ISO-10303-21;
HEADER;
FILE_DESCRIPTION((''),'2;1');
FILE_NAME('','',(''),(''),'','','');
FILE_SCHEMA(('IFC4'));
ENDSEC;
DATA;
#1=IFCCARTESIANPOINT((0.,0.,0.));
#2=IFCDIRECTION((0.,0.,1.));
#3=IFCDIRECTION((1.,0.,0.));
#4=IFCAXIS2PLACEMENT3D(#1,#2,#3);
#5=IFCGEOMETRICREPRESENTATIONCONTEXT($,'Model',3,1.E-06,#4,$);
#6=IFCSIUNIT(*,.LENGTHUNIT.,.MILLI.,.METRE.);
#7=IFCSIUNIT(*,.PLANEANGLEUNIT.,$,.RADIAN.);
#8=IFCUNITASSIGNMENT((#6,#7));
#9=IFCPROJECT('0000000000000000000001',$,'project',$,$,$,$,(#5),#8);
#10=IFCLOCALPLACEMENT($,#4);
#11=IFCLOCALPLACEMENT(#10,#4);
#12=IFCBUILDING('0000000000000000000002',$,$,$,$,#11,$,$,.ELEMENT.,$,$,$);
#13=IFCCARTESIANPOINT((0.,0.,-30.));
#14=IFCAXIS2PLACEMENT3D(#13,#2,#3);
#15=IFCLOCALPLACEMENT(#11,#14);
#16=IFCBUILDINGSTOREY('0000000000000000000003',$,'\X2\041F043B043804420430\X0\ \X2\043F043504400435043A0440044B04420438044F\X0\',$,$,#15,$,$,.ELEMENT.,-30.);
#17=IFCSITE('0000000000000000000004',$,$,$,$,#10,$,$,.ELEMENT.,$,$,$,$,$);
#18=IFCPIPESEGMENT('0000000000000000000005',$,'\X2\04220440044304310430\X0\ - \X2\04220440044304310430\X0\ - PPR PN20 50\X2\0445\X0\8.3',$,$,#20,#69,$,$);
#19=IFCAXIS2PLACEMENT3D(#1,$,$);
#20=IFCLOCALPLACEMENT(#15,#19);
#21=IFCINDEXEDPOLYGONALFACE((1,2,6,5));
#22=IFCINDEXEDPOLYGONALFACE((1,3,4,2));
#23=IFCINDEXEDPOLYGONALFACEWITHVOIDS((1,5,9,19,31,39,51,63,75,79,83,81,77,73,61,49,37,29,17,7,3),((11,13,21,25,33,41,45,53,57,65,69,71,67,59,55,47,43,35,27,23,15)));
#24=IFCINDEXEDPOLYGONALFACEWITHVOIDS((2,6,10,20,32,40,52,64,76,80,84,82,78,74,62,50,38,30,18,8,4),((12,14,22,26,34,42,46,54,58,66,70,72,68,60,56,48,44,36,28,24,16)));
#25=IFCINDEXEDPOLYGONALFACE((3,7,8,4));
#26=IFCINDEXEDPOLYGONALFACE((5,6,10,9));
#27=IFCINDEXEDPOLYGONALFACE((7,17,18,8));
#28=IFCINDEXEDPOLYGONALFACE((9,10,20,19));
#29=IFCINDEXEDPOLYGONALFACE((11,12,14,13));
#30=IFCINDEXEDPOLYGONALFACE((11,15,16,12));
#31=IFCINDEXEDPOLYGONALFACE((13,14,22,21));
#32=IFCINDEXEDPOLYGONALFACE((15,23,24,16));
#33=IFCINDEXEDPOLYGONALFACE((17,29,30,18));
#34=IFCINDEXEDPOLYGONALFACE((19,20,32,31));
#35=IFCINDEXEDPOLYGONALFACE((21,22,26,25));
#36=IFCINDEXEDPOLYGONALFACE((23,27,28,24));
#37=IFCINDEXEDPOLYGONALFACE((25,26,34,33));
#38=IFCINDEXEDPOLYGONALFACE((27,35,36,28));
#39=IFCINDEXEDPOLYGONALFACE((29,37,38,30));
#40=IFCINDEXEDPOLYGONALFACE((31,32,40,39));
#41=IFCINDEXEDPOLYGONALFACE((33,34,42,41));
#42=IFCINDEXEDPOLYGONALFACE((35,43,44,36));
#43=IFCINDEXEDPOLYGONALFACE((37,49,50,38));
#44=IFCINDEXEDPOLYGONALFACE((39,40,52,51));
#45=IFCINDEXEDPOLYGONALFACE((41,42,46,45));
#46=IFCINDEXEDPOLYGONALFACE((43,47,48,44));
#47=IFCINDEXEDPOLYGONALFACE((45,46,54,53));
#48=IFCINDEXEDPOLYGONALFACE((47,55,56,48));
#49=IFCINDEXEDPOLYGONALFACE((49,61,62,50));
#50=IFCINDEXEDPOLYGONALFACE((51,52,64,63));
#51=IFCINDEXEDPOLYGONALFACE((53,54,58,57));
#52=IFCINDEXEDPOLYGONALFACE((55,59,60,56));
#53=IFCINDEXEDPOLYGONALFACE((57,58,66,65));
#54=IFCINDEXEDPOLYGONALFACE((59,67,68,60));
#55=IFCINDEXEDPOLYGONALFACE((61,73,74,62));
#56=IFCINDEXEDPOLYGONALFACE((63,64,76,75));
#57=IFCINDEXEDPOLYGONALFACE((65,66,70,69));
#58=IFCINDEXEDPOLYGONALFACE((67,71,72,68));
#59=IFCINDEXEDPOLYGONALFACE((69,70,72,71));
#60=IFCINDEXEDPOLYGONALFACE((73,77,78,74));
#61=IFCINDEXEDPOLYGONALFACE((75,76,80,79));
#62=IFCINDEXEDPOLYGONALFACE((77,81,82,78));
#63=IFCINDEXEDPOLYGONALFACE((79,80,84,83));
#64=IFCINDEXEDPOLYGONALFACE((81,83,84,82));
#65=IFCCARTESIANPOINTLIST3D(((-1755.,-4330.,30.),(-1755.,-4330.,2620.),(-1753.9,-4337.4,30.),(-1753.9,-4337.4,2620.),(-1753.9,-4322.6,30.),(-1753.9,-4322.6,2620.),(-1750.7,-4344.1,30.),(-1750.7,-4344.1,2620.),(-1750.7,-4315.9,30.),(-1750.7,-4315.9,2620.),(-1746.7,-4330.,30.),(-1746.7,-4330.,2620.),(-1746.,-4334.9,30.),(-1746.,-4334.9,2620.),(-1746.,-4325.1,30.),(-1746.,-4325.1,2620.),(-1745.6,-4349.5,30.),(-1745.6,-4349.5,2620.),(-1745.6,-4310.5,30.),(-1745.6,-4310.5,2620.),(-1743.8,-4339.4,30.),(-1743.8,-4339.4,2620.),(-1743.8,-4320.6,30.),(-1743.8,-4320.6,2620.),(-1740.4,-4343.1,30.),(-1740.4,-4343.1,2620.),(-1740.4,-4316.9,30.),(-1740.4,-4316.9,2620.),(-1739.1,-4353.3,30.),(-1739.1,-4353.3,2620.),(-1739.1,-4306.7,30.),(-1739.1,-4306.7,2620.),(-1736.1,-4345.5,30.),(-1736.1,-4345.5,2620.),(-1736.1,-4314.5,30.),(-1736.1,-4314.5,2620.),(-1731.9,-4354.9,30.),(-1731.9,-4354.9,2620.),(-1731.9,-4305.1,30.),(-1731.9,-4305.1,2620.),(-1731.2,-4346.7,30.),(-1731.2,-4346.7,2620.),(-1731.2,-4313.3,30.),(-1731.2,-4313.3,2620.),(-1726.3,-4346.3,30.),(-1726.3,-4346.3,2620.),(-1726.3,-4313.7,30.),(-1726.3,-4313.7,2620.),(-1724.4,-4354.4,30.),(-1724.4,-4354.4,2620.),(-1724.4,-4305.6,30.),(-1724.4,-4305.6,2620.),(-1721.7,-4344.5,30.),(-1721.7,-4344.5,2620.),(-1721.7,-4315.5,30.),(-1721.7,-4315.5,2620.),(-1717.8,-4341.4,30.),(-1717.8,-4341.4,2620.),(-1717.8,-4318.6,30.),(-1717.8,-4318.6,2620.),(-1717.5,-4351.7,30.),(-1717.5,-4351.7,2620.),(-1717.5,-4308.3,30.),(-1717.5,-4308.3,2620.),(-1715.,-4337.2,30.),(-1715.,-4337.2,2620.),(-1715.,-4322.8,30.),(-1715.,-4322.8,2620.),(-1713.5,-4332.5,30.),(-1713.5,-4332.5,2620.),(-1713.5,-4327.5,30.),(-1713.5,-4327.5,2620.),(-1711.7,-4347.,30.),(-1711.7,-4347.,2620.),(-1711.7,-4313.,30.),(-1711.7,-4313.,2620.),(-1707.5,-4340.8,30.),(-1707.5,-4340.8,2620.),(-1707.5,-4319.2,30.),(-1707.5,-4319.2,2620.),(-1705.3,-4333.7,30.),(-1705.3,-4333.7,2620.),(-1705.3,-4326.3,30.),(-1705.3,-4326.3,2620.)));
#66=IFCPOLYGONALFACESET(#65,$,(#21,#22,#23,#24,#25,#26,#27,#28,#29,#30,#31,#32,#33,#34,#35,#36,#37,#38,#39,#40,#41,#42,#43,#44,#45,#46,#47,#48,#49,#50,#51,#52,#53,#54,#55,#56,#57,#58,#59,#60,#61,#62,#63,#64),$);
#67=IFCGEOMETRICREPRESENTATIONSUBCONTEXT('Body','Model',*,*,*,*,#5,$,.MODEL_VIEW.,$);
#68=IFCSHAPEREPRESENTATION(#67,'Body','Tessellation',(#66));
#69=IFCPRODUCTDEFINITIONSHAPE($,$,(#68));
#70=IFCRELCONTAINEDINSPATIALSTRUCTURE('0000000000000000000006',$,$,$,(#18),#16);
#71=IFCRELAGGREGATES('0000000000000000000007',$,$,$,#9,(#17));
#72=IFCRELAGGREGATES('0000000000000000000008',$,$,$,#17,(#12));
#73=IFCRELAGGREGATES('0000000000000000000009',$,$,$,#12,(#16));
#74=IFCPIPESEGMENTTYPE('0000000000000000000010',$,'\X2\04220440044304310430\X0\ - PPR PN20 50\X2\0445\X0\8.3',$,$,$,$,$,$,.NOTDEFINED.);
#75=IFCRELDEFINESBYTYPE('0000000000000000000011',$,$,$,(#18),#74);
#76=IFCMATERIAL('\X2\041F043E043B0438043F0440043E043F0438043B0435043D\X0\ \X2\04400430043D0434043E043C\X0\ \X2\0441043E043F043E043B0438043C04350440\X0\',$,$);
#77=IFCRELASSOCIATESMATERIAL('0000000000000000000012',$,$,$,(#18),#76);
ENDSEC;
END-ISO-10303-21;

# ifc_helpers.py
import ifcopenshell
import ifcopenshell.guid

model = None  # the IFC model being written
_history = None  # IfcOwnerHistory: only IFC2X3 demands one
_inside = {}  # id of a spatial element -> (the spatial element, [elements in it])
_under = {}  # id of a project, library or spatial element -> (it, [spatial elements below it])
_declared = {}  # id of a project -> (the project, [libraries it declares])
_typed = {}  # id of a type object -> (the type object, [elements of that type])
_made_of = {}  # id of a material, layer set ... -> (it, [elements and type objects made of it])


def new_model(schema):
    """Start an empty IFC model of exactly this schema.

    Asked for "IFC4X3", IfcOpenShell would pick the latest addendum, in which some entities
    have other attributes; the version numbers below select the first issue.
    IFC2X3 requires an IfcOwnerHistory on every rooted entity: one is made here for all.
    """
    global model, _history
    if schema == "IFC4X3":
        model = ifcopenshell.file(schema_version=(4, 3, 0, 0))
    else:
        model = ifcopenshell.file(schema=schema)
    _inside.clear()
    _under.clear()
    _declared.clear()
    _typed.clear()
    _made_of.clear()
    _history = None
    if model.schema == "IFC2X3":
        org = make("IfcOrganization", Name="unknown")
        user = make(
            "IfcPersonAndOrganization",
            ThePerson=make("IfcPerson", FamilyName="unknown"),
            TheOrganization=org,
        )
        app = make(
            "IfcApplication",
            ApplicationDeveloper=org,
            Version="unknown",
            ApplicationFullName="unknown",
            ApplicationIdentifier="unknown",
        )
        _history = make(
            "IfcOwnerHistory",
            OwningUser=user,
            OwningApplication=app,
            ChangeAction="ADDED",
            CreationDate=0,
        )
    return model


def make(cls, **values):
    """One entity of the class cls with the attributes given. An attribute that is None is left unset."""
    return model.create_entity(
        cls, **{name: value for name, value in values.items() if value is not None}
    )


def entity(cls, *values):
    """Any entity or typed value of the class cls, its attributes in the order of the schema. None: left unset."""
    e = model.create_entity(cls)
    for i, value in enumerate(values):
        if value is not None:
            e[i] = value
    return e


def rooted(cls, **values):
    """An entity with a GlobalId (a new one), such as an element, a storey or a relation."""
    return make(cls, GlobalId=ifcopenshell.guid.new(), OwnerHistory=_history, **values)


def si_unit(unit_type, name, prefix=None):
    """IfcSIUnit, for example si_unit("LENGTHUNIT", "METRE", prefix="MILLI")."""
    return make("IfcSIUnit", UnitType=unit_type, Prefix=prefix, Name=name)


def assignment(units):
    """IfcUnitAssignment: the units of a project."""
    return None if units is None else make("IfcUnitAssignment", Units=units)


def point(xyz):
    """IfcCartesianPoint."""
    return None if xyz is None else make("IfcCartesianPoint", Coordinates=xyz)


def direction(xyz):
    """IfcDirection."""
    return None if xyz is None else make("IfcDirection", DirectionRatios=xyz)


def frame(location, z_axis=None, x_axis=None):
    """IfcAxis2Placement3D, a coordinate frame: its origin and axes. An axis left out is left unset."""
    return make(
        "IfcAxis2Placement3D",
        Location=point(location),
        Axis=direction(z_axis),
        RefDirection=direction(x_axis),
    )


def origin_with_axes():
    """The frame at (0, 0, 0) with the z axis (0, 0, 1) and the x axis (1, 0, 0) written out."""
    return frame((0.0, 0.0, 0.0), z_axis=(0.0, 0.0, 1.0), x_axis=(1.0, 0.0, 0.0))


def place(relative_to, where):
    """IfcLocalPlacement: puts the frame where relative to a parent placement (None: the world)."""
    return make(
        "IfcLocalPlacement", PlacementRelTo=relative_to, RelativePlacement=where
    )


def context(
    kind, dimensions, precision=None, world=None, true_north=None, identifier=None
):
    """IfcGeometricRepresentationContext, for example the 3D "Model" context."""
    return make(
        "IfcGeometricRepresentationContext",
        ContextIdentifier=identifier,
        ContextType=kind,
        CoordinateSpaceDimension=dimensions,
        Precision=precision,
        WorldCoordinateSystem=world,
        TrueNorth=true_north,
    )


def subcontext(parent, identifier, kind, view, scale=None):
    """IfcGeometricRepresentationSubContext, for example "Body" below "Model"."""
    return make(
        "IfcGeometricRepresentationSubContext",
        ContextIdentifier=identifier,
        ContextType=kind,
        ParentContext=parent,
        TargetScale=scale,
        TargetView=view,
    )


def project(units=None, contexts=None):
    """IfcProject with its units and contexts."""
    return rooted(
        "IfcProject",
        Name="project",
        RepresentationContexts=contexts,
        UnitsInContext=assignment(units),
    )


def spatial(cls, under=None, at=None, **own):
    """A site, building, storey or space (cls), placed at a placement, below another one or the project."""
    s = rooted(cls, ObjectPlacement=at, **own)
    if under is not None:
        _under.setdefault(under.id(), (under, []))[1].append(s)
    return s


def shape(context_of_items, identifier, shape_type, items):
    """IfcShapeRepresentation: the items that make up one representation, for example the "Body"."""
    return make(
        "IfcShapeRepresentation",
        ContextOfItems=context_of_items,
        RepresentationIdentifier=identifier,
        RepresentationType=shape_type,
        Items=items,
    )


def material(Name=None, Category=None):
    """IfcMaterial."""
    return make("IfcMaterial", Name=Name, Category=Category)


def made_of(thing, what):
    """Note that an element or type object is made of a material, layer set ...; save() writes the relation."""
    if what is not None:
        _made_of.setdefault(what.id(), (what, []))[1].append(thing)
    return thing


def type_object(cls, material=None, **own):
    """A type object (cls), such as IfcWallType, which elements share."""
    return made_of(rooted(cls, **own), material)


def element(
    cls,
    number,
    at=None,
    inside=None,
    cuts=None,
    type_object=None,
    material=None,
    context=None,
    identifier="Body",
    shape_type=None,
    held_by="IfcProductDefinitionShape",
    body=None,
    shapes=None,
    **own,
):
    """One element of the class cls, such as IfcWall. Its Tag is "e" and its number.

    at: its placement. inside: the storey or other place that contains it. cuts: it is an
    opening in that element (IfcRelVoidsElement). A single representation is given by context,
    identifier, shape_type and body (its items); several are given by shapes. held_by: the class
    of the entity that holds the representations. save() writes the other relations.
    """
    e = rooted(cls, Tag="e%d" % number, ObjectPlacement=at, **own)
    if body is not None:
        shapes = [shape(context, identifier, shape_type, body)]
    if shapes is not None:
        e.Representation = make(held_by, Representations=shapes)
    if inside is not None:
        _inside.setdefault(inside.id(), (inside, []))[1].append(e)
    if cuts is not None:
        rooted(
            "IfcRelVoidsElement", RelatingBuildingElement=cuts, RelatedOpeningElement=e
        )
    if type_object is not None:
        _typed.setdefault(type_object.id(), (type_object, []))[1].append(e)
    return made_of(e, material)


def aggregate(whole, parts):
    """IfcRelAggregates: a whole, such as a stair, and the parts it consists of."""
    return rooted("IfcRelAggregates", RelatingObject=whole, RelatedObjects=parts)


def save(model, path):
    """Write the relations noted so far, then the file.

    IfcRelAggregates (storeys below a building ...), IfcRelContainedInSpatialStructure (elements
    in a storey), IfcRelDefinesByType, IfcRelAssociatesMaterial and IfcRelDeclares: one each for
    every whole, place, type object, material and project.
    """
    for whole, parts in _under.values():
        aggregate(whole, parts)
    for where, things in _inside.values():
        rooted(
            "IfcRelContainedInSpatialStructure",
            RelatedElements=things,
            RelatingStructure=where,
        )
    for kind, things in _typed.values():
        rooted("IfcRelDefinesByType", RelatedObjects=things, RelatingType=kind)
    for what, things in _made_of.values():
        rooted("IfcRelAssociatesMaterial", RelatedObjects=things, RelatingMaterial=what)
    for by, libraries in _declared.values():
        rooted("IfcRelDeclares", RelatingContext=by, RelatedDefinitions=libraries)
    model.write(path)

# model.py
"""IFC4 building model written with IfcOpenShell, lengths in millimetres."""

from ifc_helpers import new_model, entity, si_unit, frame, origin_with_axes, place, context, subcontext, project, spatial, material, type_object, element, save


model = new_model("IFC4")

# Units and contexts
model_context = context("Model", 3, precision=1e-06, world=origin_with_axes())
body_context = subcontext(model_context, "Body", "Model", "MODEL_VIEW")
ifc_project = project(units=[si_unit("LENGTHUNIT", "METRE", prefix="MILLI"), si_unit("PLANEANGLEUNIT", "RADIAN")], contexts=[model_context])

# Site, building, storey
site_placement = place(None, origin_with_axes())
site = spatial("IfcSite", under=ifc_project, at=site_placement, CompositionType="ELEMENT")
building_placement = place(site_placement, origin_with_axes())
building = spatial("IfcBuilding", under=site, at=building_placement, CompositionType="ELEMENT")
storey_placement = place(building_placement, frame((0.0, 0.0, -30.0), z_axis=(0.0, 0.0, 1.0), x_axis=(1.0, 0.0, 0.0)))
storey = spatial("IfcBuildingStorey", under=building, at=storey_placement, Name="Плита перекрытия", CompositionType="ELEMENT", Elevation=-30.0)

# Pipe segment
ifc_material_1 = material(Name="Полипропилен рандом сополимер")
pipe_segment_type_1 = type_object("IfcPipeSegmentType", Name="Труба - PPR PN20 50х8.3", PredefinedType="NOTDEFINED")
pipe_segment_1_placement = place(storey_placement, frame((-1730.0, -4330.0, 2620.0), z_axis=(0.0, 0.0, 1.0), x_axis=(1.0, 0.0, 0.0)))
element("IfcPipeSegment", 1, at=pipe_segment_1_placement, inside=storey, type_object=pipe_segment_type_1, material=ifc_material_1, Name="Труба - Труба - PPR PN20 50х8.3", context=body_context, shape_type="AdvancedSweptSolid", body=[
    entity("IfcSweptDiskSolid", entity("IfcIndexedPolyCurve", entity("IfcCartesianPointList3D", [[0.0, 0.0, 0.0], [0.0, 0.0, -2590.0]]), [entity("IfcLineIndex", [1, 2])]), 25.0, 16.7),
])

save(model, "model.ifc")
